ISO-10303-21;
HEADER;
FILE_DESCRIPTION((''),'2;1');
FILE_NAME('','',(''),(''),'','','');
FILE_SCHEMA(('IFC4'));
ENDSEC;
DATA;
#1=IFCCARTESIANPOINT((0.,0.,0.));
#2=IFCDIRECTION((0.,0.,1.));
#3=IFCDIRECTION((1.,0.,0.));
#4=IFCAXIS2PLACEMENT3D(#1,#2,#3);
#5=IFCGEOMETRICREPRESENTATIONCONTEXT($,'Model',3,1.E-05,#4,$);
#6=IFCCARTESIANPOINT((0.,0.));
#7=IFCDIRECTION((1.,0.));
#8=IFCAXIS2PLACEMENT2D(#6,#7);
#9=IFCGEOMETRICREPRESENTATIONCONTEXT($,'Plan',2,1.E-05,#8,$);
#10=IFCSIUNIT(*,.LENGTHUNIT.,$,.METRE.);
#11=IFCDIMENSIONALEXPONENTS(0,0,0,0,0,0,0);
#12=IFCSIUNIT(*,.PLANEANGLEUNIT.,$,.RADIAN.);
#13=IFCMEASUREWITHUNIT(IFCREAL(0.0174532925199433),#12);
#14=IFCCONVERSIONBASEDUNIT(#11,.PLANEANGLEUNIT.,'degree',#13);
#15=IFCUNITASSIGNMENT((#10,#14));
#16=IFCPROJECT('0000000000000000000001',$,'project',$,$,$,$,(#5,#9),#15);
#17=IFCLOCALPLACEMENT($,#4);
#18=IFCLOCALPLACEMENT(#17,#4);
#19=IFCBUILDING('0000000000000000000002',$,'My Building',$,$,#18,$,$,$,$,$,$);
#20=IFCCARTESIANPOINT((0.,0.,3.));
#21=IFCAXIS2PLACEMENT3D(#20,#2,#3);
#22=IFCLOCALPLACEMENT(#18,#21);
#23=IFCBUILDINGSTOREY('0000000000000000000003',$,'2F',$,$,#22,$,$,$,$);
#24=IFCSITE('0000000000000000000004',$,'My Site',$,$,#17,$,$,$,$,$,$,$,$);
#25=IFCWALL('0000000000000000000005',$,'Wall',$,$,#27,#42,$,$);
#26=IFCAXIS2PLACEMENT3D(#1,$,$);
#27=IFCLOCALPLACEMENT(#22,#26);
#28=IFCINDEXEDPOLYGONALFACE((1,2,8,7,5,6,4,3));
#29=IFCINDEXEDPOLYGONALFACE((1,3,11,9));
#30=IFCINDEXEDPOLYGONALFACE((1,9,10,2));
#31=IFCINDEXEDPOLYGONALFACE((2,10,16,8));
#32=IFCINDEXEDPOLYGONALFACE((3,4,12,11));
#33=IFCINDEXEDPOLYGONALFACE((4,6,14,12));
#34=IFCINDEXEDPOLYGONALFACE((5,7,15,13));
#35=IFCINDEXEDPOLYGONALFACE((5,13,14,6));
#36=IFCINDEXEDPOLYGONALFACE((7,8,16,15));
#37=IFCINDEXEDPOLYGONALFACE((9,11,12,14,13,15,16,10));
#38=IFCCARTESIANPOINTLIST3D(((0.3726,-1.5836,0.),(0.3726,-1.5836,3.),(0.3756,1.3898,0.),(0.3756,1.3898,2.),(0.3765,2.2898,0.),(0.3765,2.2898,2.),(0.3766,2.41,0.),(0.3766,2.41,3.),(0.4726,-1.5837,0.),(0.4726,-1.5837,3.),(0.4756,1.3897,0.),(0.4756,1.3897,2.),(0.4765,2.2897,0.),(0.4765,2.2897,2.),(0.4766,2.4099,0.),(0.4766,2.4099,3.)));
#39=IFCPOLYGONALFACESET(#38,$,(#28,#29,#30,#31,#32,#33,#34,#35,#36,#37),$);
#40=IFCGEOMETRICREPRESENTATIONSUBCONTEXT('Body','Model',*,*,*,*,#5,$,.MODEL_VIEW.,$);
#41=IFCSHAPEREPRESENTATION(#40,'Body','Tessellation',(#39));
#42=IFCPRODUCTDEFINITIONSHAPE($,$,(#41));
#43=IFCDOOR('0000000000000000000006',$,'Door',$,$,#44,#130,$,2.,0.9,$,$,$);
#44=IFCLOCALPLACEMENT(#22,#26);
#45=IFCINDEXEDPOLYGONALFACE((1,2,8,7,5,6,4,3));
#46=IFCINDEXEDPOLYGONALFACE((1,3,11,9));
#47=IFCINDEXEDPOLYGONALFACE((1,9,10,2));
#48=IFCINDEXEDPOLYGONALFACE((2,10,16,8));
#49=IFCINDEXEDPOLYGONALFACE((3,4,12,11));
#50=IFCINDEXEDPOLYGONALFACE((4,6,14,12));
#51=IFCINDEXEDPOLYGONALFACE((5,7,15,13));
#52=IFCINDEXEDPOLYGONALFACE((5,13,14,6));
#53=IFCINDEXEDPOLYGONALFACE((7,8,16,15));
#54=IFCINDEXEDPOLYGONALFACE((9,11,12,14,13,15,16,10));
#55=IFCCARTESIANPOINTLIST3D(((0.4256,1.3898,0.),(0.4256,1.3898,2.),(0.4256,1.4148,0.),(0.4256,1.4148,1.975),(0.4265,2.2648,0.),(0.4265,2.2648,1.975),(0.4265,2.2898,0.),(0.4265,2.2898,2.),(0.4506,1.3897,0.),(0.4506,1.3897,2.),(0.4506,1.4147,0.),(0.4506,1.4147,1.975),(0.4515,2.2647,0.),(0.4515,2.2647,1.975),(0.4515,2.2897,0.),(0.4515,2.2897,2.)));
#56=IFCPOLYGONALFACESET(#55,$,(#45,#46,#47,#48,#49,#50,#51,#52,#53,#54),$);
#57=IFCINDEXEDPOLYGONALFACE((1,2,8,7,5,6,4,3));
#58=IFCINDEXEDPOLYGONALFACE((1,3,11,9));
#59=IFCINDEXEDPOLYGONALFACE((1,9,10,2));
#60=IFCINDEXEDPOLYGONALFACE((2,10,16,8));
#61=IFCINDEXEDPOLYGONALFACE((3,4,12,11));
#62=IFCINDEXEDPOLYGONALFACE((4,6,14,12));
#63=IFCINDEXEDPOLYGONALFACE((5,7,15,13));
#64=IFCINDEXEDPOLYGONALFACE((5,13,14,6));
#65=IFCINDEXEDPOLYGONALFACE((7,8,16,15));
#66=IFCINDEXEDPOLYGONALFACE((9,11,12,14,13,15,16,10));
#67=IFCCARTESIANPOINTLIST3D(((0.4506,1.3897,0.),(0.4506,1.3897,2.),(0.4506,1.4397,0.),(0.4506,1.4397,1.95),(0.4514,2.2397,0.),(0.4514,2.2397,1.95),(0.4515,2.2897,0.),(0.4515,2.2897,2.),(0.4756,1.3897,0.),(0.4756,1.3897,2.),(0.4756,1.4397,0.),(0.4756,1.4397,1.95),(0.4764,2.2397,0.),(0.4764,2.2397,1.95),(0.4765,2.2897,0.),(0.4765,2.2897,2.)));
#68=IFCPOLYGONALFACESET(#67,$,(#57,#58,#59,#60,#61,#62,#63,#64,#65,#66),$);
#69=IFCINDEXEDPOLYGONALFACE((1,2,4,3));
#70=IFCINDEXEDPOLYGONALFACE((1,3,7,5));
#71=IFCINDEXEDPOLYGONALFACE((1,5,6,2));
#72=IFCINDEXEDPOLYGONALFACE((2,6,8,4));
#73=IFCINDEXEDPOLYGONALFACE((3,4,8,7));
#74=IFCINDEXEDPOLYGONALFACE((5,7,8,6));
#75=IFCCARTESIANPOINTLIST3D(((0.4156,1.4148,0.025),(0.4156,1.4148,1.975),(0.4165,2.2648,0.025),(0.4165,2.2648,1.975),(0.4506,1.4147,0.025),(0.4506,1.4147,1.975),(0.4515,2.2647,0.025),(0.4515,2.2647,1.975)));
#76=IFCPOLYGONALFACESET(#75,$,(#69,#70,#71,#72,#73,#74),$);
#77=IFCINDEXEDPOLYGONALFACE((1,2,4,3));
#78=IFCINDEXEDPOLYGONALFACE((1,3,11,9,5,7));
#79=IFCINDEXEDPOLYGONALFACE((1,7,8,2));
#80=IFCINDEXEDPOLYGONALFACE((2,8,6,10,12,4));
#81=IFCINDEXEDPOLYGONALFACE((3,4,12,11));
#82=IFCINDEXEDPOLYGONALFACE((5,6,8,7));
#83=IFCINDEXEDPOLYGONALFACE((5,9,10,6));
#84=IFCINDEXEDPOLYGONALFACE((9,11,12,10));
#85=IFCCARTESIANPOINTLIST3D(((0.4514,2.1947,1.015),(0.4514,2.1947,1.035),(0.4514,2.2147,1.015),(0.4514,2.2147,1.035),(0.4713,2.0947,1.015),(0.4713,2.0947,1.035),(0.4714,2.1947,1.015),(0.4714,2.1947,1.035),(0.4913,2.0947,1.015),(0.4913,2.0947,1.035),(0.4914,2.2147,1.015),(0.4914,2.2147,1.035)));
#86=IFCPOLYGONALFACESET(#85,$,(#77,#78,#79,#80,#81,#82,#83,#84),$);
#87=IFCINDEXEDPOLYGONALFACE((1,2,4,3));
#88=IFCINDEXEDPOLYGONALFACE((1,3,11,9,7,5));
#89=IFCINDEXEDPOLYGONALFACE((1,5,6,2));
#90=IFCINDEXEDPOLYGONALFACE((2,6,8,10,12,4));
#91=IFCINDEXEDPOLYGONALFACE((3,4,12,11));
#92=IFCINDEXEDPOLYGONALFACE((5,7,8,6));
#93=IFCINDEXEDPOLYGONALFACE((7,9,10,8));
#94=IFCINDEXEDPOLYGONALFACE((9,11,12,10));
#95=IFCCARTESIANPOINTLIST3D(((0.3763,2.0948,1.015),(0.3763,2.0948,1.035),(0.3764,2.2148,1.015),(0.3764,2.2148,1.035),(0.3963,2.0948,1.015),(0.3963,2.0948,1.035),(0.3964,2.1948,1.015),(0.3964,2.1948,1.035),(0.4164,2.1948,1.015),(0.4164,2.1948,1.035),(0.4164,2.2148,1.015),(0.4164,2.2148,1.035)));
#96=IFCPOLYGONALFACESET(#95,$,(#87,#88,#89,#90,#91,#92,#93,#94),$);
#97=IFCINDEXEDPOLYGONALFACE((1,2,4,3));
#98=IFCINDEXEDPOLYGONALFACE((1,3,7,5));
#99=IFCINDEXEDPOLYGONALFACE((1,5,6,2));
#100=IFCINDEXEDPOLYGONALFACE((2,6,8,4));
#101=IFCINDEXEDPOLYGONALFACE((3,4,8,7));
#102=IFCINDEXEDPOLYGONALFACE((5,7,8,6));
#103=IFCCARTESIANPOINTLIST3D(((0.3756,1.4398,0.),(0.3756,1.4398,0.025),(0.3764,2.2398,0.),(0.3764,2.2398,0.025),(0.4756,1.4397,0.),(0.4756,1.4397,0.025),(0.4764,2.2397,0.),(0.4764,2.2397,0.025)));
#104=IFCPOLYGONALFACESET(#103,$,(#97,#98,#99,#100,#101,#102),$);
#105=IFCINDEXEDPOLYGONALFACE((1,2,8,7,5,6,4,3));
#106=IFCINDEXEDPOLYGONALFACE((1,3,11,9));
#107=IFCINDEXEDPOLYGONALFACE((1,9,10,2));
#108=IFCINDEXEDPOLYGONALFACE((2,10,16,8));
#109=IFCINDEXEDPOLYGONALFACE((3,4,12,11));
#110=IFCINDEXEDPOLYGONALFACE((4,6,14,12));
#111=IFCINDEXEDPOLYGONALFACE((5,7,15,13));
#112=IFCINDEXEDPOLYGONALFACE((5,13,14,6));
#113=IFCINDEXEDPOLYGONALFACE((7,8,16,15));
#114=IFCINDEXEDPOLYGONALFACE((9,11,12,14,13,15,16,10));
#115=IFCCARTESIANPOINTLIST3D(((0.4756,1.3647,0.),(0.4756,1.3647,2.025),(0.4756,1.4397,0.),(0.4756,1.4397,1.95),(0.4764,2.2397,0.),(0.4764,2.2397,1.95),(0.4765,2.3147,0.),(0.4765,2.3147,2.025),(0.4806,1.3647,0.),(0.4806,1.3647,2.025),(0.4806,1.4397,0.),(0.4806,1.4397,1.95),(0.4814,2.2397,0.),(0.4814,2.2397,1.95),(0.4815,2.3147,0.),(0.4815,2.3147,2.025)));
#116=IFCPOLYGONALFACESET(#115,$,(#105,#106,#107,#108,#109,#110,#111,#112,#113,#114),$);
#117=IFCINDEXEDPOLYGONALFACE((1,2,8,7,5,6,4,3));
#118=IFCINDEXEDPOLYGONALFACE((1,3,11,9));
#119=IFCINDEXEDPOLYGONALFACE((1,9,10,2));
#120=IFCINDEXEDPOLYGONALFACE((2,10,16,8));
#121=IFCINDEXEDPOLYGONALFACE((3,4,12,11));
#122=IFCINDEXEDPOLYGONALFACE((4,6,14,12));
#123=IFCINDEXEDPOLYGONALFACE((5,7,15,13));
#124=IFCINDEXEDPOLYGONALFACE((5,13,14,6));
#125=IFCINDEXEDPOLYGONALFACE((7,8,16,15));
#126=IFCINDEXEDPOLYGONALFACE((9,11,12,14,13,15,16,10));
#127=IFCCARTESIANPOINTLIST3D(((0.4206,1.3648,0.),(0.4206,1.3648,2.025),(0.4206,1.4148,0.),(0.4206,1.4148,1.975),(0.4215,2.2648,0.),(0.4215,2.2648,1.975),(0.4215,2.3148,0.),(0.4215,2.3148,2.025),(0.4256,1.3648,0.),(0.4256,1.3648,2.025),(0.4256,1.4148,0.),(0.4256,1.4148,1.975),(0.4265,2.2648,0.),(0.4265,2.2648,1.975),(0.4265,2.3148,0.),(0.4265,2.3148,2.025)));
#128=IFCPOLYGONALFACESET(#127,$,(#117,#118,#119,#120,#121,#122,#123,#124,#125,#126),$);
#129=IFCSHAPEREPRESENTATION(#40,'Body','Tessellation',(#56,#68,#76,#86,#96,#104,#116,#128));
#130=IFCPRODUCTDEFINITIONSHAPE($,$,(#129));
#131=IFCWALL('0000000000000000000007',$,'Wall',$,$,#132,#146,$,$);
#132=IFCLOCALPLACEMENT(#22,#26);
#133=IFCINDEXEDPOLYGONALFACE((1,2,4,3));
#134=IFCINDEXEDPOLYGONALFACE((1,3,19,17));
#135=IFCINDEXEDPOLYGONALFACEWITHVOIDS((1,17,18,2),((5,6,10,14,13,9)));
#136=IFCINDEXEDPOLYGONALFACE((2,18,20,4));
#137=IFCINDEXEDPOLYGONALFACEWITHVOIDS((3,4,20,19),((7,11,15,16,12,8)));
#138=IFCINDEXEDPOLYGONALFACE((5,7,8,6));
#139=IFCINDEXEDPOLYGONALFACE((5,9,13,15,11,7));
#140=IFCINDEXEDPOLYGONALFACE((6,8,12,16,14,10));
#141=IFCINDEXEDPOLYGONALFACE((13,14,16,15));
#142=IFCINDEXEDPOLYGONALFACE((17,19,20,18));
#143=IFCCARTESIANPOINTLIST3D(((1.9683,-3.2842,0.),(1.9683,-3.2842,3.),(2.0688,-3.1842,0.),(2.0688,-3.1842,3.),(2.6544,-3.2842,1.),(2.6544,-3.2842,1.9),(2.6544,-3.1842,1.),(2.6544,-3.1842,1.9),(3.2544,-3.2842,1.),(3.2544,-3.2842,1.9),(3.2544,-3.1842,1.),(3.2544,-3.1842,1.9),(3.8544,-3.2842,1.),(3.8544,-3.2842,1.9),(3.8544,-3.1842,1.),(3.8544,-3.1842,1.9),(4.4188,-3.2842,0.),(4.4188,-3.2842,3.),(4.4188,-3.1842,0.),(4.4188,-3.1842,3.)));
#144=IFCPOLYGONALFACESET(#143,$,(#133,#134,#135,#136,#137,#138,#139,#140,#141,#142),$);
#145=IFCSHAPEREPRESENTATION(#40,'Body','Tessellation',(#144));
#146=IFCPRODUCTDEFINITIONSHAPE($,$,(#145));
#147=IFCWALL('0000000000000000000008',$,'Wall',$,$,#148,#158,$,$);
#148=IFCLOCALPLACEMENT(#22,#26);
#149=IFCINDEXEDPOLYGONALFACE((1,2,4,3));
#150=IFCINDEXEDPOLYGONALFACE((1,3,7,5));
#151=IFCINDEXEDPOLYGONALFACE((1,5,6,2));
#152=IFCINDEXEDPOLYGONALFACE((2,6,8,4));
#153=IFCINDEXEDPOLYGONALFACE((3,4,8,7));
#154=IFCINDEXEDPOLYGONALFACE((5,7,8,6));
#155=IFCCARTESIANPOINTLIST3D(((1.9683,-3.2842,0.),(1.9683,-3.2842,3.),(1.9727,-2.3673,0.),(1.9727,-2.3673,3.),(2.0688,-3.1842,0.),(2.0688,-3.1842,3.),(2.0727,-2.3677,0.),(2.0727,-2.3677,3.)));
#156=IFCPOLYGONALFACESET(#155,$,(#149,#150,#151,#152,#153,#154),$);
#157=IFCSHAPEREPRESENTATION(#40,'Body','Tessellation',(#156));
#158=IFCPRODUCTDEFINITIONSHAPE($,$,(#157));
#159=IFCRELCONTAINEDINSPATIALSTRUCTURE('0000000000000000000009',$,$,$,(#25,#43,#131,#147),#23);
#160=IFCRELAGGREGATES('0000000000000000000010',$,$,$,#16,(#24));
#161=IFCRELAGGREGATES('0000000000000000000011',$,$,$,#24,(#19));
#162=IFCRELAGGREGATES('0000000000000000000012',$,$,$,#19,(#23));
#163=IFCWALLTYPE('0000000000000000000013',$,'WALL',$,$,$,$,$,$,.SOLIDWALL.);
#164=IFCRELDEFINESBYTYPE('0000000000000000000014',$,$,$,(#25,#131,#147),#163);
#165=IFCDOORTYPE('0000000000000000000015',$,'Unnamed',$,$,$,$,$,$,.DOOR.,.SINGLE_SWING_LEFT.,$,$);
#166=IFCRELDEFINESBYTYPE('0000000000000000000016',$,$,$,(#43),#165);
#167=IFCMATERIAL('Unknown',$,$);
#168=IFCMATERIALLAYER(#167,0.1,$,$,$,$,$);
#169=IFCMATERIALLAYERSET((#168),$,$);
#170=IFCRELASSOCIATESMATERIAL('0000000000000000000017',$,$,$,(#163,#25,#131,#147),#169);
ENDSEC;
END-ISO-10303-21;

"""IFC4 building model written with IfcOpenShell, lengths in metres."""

from ifc_helpers import new_model, entity, si_unit, converted_unit, frame, origin_with_axes, origin_2d_with_axis, place, context, subcontext, project, spatial, line, indexed_curve, outline, extrude, shape, source, transform, mapped, material, layer, layer_set, layer_usage, type_object, type_shapes, element, fill, save


model = new_model("IFC4")

# Units and contexts
model_context = context("Model", 3, precision=1e-05, world=origin_with_axes())
plan_context = context("Plan", 2, precision=1e-05, world=origin_2d_with_axis())
body_context_1 = subcontext(model_context, "Body", "Model", "MODEL_VIEW")
body_context_2 = subcontext(plan_context, "Body", "Plan", "PLAN_VIEW")
ifc_project = project(units=[si_unit("LENGTHUNIT", "METRE"), converted_unit("PLANEANGLEUNIT", "degree", entity("IfcReal", 0.0174532925199433), si_unit("PLANEANGLEUNIT", "RADIAN"), dimensions=[0, 0, 0, 0, 0, 0, 0])], contexts=[model_context, plan_context])

# Site, building, storey
site_placement = place(None, origin_with_axes())
site = spatial("IfcSite", under=ifc_project, at=site_placement, Name="My Site")
building_placement = place(site_placement, origin_with_axes())
building = spatial("IfcBuilding", under=site, at=building_placement, Name="My Building")
storey_placement = place(building_placement, frame((0.0, 0.0, 3.0), z_axis=(0.0, 0.0, 1.0), x_axis=(1.0, 0.0, 0.0)))
storey = spatial("IfcBuildingStorey", under=building, at=storey_placement, Name="2F")

# Shared definitions
ifc_material = material(Name="Unknown")
ifc_layer = layer(ifc_material, 0.1)
ifc_layer_set = layer_set([ifc_layer])
wall_type = type_object("IfcWallType", Name="WALL", PredefinedType="SOLIDWALL", material=ifc_layer_set)

# Wall, opening, door
ifc_layer_usage_1 = layer_usage(ifc_layer_set, "AXIS2", "POSITIVE", 0.0)
wall_1_placement = place(storey_placement, frame((0.4726, -1.5837, 0.0), z_axis=(0.0, 0.0, 1.0), x_axis=(0.000991, 1.0, 0.0)))
wall_1 = element("IfcWall", 1, at=wall_1_placement, inside=storey, type_object=wall_type, material=ifc_layer_usage_1, Name="Wall", context=body_context_1, shape_type="SweptSolid", body=[
    extrude(outline(indexed_curve([(0.0, 0.0), (0.0, 0.1), (3.9936, 0.1), (3.9936, 0.0)], segments=[line(1, 2, 3, 4, 1)])), origin_with_axes(), (0.0, 0.0, 1.0), 3.0),
])
shared_shape_1 = source(origin_with_axes(), body_context_1, "Body", "SweptSolid", [
    extrude(outline(indexed_curve([(0.0, 0.0), (0.9, 0.0), (0.9, 2.0), (0.0, 2.0)], segments=[line(1, 2, 3, 4, 1)])), frame((0.0, -0.6, 0.0), z_axis=(0.0, -1.0, 0.0), x_axis=(1.0, 0.0, 0.0)), (0.0, 0.0, -1.0), 1.2),
])
opening_1_placement = place(wall_1_placement, frame((2.9734, 0.0, 0.0), z_axis=(0.0, 0.0, 1.0), x_axis=(1.0, 0.0, 0.0)))
opening_1 = element("IfcOpeningElement", 2, at=opening_1_placement, cuts=wall_1, PredefinedType="OPENING", context=body_context_1, shape_type="MappedRepresentation", body=[
    mapped(shared_shape_1, transform((0.0, 0.0, 0.0), x_axis=(1.0, 0.0, 0.0), y_axis=(0.0, 1.0, 0.0), z_axis=(0.0, 0.0, 1.0), scale=1.0)),
])
door_type = type_object("IfcDoorType", Name="Unnamed", OperationType="SINGLE_SWING_LEFT", PredefinedType="DOOR")
shared_shape_2 = source(origin_with_axes(), body_context_1, "Body", "SweptSolid", [
    extrude(outline(indexed_curve([(0.0, 0.0), (0.0, 2.0), (0.9, 2.0), (0.9, 0.0), (0.875, 0.0), (0.875, 1.975), (0.025, 1.975), (0.025, 0.0)], segments=[line(1, 2, 3, 4, 5, 6, 7, 8, 1)])), frame((0.0, 0.025, 0.0), z_axis=(0.0, -1.0, 0.0), x_axis=(1.0, 0.0, 0.0)), (0.0, 0.0, -1.0), 0.025),
    extrude(outline(indexed_curve([(0.0, 0.0), (0.0, 2.0), (0.9, 2.0), (0.9, 0.0), (0.85, 0.0), (0.85, 1.95), (0.05, 1.95), (0.05, 0.0)], segments=[line(1, 2, 3, 4, 5, 6, 7, 8, 1)])), frame((0.0, 0.0, 0.0), z_axis=(0.0, -1.0, 0.0), x_axis=(1.0, 0.0, 0.0)), (0.0, 0.0, -1.0), 0.025),
    extrude(outline(indexed_curve([(0.0, 0.0), (0.85, 0.0), (0.85, 0.035), (0.0, 0.035)], segments=[line(1, 2, 3, 4, 1)])), frame((0.025, 0.025, 0.025), z_axis=(0.0, 0.0, 1.0), x_axis=(1.0, 0.0, 0.0)), (0.0, 0.0, 1.0), 1.95),
    extrude(outline(indexed_curve([(0.0, 0.0), (0.0, -0.04), (-0.12, -0.04), (-0.12, -0.02), (-0.02, -0.02), (-0.02, 0.0)], segments=[line(1, 2, 3, 4, 5, 6, 1)])), frame((0.825, 0.025, 1.015), z_axis=(0.0, 0.0, 1.0), x_axis=(1.0, 0.0, 0.0)), (0.0, 0.0, 1.0), 0.02),
    extrude(outline(indexed_curve([(0.0, 0.0), (0.0, 0.04), (-0.12, 0.04), (-0.12, 0.02), (-0.02, 0.02), (-0.02, 0.0)], segments=[line(1, 2, 3, 4, 5, 6, 1)])), frame((0.825, 0.06, 1.015), z_axis=(0.0, 0.0, 1.0), x_axis=(1.0, 0.0, 0.0)), (0.0, 0.0, 1.0), 0.02),
    extrude(outline(indexed_curve([(0.0, 0.0), (0.8, 0.0), (0.8, 0.1), (0.0, 0.1)], segments=[line(1, 2, 3, 4, 1)])), frame((0.05, 0.0, 0.0), z_axis=(0.0, 0.0, 1.0), x_axis=(1.0, 0.0, 0.0)), (0.0, 0.0, 1.0), 0.025),
    extrude(outline(indexed_curve([(0.0, 0.0), (0.0, 2.025), (0.95, 2.025), (0.95, 0.0), (0.875, 0.0), (0.875, 1.95), (0.075, 1.95), (0.075, 0.0)], segments=[line(1, 2, 3, 4, 5, 6, 7, 8, 1)])), frame((-0.025, -0.005, 0.0), z_axis=(0.0, -1.0, 0.0), x_axis=(1.0, 0.0, 0.0)), (0.0, 0.0, -1.0), 0.005),
    extrude(outline(indexed_curve([(0.0, 0.0), (0.0, 2.025), (0.95, 2.025), (0.95, 0.0), (0.9, 0.0), (0.9, 1.975), (0.05, 1.975), (0.05, 0.0)], segments=[line(1, 2, 3, 4, 5, 6, 7, 8, 1)])), frame((-0.025, 0.05, 0.0), z_axis=(0.0, -1.0, 0.0), x_axis=(1.0, 0.0, 0.0)), (0.0, 0.0, -1.0), 0.005),
])
shared_shape_3 = source(origin_with_axes(), body_context_2, "Body", "Curve2D", [
    entity("IfcIndexedPolyCurve", entity("IfcCartesianPointList2D", [[0.0, 0.0], [0.0, 0.05], [0.025, 0.05], [0.025, 0.025], [0.05, 0.025], [0.05, 0.0]]), [entity("IfcLineIndex", [1, 2, 3, 4, 5, 6, 1])]),
    entity("IfcIndexedPolyCurve", entity("IfcCartesianPointList2D", [[0.9, 0.0], [0.9, 0.05], [0.875, 0.05], [0.875, 0.025], [0.85, 0.025], [0.85, 0.0]]), [entity("IfcLineIndex", [1, 2, 3, 4, 5, 6, 1])]),
    entity("IfcTrimmedCurve", entity("IfcEllipse", entity("IfcAxis2Placement2D", entity("IfcCartesianPoint", [0.06, 0.05]), entity("IfcDirection", [1.0, 0.0])), 0.815, 0.85), [entity("IfcCartesianPoint", [0.875, 0.05])], [entity("IfcCartesianPoint", [0.06, 0.9])], True, "CARTESIAN"),
    entity("IfcIndexedPolyCurve", entity("IfcCartesianPointList2D", [[0.025, 0.05], [0.06, 0.05], [0.06, 0.9], [0.025, 0.9]]), [entity("IfcLineIndex", [1, 2, 3, 4, 1])]),
])
type_shapes(door_type, [shared_shape_2, shared_shape_3])
door_1_placement = place(opening_1_placement, frame((0.0, 0.0, 0.0), z_axis=(0.0, 0.0, 1.0), x_axis=(1.0, 0.0, 0.0)))
door_1 = element("IfcDoor", 3, at=door_1_placement, inside=storey, type_object=door_type, Name="Door", OverallHeight=2.0, OverallWidth=0.9, shapes=[
    shape(body_context_1, "Body", "MappedRepresentation", [mapped(shared_shape_2, transform((0.0, 0.0, 0.0), x_axis=(1.0, 0.0, 0.0), y_axis=(0.0, 1.0, 0.0), z_axis=(0.0, 0.0, 1.0), scale=1.0))]),
    shape(body_context_2, "Body", "MappedRepresentation", [mapped(shared_shape_3, transform((0.0, 0.0, 0.0), x_axis=(1.0, 0.0, 0.0), y_axis=(0.0, 1.0, 0.0), z_axis=(0.0, 0.0, 1.0), scale=1.0))]),
])
fill(opening_1, door_1)

# Wall, openings
ifc_layer_usage_2 = layer_usage(ifc_layer_set, "AXIS2", "POSITIVE", 0.0)
wall_2_placement = place(storey_placement, frame((4.4188, -3.1842, 0.0), z_axis=(0.0, 0.0, 1.0), x_axis=(-1.0, 0.0, 0.0)))
wall_2 = element("IfcWall", 4, at=wall_2_placement, inside=storey, type_object=wall_type, material=ifc_layer_usage_2, Name="Wall", context=body_context_1, shape_type="SweptSolid", body=[
    extrude(outline(indexed_curve([(0.0, 0.0), (0.0, 0.1), (2.4505, 0.1), (2.35, 0.0)], segments=[line(1, 2, 3, 4, 1)])), origin_with_axes(), (0.0, 0.0, 1.0), 3.0),
])
shared_shape_4 = source(origin_with_axes(), body_context_1, "Body", "SweptSolid", [
    extrude(outline(indexed_curve([(0.0, 0.0), (0.6, 0.0), (0.6, 0.9), (0.0, 0.9)], segments=[line(1, 2, 3, 4, 1)])), frame((0.0, -0.6, 0.0), z_axis=(0.0, -1.0, 0.0), x_axis=(1.0, 0.0, 0.0)), (0.0, 0.0, -1.0), 1.2),
])
opening_2_placement = place(wall_2_placement, frame((0.5644, 0.0, 1.0), z_axis=(0.0, 0.0, 1.0), x_axis=(1.0, 0.0, 0.0)))
element("IfcOpeningElement", 5, at=opening_2_placement, cuts=wall_2, PredefinedType="OPENING", context=body_context_1, shape_type="MappedRepresentation", body=[
    mapped(shared_shape_4, transform((0.0, 0.0, 0.0), x_axis=(1.0, 0.0, 0.0), y_axis=(0.0, 1.0, 0.0), z_axis=(0.0, 0.0, 1.0), scale=1.0)),
])
opening_3_placement = place(wall_2_placement, frame((1.1644, 0.0, 1.0), z_axis=(0.0, 0.0, 1.0), x_axis=(1.0, 0.0, 0.0)))
element("IfcOpeningElement", 6, at=opening_3_placement, cuts=wall_2, PredefinedType="OPENING", context=body_context_1, shape_type="MappedRepresentation", body=[
    mapped(shared_shape_4, transform((0.0, 0.0, 0.0), x_axis=(1.0, 0.0, 0.0), y_axis=(0.0, 1.0, 0.0), z_axis=(0.0, 0.0, 1.0), scale=1.0)),
])

# Wall
ifc_layer_usage_3 = layer_usage(ifc_layer_set, "AXIS2", "POSITIVE", 0.0)
wall_3_placement = place(storey_placement, frame((2.0688, -3.1842, 0.0), z_axis=(0.0, 0.0, 1.0), x_axis=(0.00477, 0.999989, 0.0)))
element("IfcWall", 7, at=wall_3_placement, inside=storey, type_object=wall_type, material=ifc_layer_usage_3, Name="Wall", context=body_context_1, shape_type="SweptSolid", body=[
    extrude(outline(indexed_curve([(0.0, 0.0), (-0.1005, 0.1), (0.8165, 0.1), (0.8165, 0.0)], segments=[line(1, 2, 3, 4, 1)])), origin_with_axes(), (0.0, 0.0, 1.0), 3.0),
])

save(model, "model.ifc")
